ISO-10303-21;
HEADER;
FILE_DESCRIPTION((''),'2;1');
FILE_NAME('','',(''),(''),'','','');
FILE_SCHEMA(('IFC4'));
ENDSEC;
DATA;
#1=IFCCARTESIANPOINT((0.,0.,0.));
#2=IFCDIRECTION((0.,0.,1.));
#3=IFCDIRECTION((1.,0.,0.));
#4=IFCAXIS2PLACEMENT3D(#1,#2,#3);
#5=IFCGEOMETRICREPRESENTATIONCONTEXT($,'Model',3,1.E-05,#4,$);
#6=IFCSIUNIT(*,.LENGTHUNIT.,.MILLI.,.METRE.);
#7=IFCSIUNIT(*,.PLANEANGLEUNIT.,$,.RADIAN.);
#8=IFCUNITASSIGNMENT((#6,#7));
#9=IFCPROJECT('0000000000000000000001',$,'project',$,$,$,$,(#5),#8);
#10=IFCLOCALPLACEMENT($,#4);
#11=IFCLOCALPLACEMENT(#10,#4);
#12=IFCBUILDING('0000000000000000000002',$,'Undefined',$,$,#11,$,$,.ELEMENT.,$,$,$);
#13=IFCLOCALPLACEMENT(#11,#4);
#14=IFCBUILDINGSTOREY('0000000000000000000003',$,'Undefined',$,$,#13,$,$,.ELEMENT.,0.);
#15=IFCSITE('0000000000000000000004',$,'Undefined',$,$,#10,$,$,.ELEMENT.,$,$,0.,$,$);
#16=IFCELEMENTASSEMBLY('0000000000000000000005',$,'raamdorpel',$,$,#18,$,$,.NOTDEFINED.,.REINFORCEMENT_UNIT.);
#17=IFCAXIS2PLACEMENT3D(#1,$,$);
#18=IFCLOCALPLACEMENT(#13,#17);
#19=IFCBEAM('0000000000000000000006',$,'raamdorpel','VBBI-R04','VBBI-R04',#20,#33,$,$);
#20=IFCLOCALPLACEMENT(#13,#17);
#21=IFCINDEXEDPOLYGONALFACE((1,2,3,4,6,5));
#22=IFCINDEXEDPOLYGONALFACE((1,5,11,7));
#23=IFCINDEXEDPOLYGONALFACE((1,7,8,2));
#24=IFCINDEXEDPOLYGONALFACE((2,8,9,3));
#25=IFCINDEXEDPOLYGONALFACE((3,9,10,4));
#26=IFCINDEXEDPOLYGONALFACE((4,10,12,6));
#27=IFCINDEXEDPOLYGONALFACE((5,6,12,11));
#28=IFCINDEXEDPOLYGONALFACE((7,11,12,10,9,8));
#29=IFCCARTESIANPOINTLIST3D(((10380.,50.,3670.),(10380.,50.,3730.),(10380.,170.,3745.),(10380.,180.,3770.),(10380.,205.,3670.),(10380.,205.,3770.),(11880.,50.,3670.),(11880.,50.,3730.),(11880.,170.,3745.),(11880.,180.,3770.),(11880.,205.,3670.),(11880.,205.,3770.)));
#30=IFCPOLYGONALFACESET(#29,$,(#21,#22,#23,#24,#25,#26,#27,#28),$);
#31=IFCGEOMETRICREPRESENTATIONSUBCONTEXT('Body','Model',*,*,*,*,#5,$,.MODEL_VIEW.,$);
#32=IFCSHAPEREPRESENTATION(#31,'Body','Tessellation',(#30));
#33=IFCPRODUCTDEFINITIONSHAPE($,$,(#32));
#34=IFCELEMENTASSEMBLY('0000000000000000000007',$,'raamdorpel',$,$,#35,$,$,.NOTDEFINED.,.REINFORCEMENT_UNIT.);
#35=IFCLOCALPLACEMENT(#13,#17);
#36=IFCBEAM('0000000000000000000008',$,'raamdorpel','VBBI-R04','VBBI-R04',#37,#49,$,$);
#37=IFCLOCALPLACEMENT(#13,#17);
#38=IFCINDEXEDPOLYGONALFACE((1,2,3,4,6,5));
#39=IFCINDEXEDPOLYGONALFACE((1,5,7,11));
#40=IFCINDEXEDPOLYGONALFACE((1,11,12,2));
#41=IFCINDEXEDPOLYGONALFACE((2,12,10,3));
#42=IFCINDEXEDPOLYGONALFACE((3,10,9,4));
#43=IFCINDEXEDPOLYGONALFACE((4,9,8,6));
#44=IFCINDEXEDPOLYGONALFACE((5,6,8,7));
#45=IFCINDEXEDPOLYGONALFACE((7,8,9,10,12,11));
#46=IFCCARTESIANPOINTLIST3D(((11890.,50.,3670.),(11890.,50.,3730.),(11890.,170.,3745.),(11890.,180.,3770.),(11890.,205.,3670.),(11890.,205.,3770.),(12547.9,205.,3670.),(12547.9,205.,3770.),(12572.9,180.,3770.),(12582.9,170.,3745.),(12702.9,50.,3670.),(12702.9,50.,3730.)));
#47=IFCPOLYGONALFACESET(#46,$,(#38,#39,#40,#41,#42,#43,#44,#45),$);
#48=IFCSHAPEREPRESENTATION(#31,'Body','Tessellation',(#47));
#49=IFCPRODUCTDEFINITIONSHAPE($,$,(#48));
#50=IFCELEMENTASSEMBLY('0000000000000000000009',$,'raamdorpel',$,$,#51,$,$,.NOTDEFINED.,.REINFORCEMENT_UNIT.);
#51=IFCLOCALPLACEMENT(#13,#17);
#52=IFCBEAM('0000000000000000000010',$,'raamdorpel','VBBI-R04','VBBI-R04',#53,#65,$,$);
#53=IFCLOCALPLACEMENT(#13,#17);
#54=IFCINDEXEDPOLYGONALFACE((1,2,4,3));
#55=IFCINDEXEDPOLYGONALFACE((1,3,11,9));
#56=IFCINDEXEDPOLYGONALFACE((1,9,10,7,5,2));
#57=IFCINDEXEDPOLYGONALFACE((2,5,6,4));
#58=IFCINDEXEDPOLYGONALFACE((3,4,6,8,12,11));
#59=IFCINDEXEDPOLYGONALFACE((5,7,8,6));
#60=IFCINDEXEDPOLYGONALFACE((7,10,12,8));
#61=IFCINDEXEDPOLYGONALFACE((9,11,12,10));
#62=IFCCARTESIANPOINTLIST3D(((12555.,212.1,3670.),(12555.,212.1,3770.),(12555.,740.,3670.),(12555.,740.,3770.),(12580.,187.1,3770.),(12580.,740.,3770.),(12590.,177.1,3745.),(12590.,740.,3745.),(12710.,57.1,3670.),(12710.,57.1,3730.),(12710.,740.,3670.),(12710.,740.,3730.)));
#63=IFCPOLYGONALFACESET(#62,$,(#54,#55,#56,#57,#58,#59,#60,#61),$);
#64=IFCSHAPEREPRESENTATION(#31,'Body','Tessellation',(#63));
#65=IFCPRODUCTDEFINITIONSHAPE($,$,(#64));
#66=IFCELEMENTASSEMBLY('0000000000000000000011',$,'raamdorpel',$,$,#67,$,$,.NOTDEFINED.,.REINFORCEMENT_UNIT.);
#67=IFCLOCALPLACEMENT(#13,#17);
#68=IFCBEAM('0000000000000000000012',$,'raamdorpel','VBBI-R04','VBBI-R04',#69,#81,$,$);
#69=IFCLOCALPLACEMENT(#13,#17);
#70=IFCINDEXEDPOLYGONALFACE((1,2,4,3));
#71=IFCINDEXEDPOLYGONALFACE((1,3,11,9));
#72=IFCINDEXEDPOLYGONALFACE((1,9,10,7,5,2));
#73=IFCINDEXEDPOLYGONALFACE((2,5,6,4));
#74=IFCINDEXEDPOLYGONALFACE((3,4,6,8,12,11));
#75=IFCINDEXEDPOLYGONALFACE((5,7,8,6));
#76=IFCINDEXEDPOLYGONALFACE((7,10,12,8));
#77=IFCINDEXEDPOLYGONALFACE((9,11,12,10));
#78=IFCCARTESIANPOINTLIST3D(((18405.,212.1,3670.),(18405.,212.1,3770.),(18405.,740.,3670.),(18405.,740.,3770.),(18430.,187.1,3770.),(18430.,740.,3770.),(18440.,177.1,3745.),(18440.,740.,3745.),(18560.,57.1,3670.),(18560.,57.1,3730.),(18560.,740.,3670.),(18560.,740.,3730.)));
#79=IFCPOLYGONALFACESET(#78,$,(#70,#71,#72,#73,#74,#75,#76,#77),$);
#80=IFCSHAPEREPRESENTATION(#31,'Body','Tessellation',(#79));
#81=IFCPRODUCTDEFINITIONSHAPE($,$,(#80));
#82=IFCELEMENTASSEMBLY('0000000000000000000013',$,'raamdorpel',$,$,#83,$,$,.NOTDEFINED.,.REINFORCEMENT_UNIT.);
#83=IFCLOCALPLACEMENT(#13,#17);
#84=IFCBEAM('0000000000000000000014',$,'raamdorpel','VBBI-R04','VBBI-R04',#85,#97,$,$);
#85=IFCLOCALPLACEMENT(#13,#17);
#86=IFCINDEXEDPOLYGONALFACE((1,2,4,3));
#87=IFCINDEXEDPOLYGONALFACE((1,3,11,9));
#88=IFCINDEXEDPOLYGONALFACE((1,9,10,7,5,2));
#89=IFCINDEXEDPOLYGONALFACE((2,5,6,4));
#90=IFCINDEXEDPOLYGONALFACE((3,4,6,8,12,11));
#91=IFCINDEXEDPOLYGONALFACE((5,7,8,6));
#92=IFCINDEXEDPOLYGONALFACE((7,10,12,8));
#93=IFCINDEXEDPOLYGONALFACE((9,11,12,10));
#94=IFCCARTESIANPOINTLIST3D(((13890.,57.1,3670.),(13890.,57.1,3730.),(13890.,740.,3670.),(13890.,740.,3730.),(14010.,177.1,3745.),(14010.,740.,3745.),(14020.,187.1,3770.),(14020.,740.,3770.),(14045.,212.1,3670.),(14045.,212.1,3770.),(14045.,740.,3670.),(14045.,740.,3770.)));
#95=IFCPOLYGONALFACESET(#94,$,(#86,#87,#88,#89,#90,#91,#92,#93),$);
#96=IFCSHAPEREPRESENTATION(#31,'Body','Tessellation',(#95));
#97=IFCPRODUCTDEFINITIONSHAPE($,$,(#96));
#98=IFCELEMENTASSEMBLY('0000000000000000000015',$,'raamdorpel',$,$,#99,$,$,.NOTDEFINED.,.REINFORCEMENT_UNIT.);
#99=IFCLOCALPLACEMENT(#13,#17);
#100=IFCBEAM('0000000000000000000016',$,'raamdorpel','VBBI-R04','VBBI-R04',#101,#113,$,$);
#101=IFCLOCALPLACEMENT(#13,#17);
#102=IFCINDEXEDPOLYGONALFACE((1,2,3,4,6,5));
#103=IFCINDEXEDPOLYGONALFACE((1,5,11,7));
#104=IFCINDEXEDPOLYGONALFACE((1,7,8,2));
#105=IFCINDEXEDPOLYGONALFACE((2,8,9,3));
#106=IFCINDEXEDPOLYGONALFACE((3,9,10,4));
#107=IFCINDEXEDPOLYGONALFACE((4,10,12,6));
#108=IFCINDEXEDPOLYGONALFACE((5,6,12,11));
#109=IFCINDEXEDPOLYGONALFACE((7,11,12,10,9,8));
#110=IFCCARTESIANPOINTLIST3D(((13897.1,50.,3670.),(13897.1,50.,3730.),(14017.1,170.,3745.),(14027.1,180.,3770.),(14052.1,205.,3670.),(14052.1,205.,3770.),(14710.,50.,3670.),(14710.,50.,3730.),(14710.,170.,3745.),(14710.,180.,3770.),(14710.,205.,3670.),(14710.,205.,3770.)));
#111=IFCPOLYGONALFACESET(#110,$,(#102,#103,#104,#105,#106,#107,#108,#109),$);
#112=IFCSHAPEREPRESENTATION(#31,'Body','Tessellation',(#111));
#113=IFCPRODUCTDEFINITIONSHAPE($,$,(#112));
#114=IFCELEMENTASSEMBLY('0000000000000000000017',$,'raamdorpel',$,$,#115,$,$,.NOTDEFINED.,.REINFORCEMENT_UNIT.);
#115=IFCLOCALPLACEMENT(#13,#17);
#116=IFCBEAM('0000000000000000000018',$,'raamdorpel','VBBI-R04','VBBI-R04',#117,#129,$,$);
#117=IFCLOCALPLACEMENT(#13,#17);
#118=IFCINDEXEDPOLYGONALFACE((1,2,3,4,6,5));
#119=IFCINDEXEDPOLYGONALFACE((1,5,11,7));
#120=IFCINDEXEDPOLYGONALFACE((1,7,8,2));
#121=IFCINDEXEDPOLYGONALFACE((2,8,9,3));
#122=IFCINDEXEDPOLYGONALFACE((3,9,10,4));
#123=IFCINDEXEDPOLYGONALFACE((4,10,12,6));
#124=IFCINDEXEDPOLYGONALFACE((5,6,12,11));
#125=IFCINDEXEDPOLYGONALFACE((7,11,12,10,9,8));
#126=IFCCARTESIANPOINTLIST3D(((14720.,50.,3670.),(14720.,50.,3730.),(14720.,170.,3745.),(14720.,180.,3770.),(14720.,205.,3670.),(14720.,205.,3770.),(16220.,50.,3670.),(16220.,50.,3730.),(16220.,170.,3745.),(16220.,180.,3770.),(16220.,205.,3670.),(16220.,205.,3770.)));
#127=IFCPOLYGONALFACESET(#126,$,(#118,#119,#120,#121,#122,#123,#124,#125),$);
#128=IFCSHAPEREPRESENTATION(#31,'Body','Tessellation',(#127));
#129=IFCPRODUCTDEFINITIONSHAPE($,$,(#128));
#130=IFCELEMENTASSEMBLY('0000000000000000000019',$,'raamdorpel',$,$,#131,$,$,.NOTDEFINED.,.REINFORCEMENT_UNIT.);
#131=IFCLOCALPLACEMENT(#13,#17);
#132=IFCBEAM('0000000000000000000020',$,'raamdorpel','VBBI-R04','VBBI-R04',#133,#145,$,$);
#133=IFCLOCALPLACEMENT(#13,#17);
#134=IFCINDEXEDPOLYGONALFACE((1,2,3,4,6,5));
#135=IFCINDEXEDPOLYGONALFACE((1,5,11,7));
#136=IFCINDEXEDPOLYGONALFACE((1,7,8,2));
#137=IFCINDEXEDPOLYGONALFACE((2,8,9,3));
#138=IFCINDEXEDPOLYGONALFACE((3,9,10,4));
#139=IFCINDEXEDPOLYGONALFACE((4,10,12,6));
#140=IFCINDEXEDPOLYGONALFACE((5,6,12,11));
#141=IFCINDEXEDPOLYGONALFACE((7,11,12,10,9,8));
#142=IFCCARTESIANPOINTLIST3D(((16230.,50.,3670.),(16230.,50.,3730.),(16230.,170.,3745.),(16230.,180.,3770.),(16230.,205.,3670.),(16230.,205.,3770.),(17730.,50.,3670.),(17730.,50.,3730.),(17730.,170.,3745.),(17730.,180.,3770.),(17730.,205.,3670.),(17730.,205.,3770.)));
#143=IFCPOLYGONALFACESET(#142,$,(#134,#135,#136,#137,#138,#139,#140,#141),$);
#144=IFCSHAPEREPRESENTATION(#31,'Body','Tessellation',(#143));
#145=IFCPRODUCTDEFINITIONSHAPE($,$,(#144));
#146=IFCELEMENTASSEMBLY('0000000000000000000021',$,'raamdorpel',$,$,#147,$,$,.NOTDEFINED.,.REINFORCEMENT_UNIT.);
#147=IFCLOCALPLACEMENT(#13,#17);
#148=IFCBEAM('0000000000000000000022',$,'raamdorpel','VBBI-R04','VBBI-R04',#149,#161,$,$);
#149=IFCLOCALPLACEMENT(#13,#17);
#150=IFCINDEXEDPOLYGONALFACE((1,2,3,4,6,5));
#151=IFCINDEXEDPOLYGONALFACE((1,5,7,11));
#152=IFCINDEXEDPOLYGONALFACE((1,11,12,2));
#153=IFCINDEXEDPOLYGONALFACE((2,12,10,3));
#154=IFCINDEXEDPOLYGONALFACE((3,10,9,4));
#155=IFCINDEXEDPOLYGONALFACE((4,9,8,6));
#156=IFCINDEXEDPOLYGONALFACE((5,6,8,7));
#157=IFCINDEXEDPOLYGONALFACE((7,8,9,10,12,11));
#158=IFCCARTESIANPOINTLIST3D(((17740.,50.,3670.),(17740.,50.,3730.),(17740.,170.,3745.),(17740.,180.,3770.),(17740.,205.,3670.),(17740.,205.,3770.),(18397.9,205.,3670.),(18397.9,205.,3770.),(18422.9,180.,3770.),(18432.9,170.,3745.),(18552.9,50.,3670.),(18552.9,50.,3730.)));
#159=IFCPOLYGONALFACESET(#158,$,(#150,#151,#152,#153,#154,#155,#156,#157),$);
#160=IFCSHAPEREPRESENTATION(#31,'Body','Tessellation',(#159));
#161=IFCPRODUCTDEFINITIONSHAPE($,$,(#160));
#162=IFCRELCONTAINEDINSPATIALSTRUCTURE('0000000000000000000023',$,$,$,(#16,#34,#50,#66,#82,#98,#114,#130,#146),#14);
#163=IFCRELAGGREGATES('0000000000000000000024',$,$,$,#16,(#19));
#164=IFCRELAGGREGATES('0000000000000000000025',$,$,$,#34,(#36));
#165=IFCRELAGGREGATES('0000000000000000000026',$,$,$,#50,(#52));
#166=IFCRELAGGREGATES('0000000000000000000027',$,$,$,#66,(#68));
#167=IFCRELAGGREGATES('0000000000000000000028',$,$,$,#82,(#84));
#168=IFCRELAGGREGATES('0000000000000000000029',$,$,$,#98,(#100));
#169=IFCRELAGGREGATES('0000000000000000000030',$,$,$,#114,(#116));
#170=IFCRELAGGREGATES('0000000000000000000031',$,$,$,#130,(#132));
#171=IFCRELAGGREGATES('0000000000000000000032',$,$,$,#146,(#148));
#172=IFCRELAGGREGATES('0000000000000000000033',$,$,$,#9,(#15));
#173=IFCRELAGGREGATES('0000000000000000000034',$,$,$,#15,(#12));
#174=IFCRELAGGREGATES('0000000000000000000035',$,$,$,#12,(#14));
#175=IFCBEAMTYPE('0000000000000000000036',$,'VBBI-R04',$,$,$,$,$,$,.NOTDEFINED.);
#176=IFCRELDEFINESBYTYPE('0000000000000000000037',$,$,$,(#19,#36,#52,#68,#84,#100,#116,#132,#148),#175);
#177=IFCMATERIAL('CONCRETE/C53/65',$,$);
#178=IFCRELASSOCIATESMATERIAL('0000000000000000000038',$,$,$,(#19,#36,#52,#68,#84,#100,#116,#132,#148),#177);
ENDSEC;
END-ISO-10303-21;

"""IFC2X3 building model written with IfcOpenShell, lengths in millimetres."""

from ifc_helpers import new_model, si_unit, frame, origin_with_axes, place, context, subcontext, project, spatial, polyline, outline, extrude, clip, halfspace, material, type_object, element, aggregate, save


model = new_model("IFC2X3")

# Units and contexts
model_context = context("Model", 3, precision=1e-05, world=origin_with_axes())
body_context = subcontext(model_context, "Body", "Model", "MODEL_VIEW")
ifc_project = project(units=[si_unit("LENGTHUNIT", "METRE", prefix="MILLI"), si_unit("PLANEANGLEUNIT", "RADIAN")], contexts=[model_context])

# Site, building, storey
site_placement = place(None, origin_with_axes())
site = spatial("IfcSite", under=ifc_project, at=site_placement, Name="Undefined", CompositionType="ELEMENT", RefElevation=0.0)
building_placement = place(site_placement, origin_with_axes())
building = spatial("IfcBuilding", under=site, at=building_placement, Name="Undefined", CompositionType="ELEMENT")
storey_placement = place(building_placement, origin_with_axes())
storey = spatial("IfcBuildingStorey", under=building, at=storey_placement, Name="Undefined", CompositionType="ELEMENT", Elevation=0.0)

# Element assemblies, beams
ifc_material = material(Name="CONCRETE/C53/65")
beam_type_1 = type_object("IfcBeamType", Name="VBBI-R04", PredefinedType="NOTDEFINED")
assembly_1_placement = place(storey_placement, origin_with_axes())
assembly_1 = element("IfcElementAssembly", 1, at=assembly_1_placement, inside=storey, Name="raamdorpel", AssemblyPlace="NOTDEFINED", PredefinedType="REINFORCEMENT_UNIT")
beam_1_placement = place(assembly_1_placement, frame((10380.0, 127.5, 3720.0), z_axis=(0.0, -1.0, 0.0), x_axis=(1.0, 0.0, 0.0)))
beam_1 = element("IfcBeam", 2, at=beam_1_placement, type_object=beam_type_1, material=ifc_material, Name="raamdorpel", Description="VBBI-R04", ObjectType="VBBI-R04", context=body_context, shape_type="SweptSolid", body=[
    extrude(outline(polyline([(50.0, -77.5), (-50.0, -77.5), (-50.0, -52.5), (-25.0, -42.5), (-10.0, 77.5), (50.0, 77.5), (50.0, -77.5)])), frame((1500.0, 0.0, 0.0), z_axis=(-1.0, 0.0, 0.0), x_axis=(0.0, -1.0, 0.0)), (0.0, 0.0, 1.0), 1500.0),
])
aggregate(assembly_1, [beam_1])
assembly_2_placement = place(storey_placement, origin_with_axes())
assembly_2 = element("IfcElementAssembly", 3, at=assembly_2_placement, inside=storey, Name="raamdorpel", AssemblyPlace="NOTDEFINED", PredefinedType="REINFORCEMENT_UNIT")
beam_2_placement = place(assembly_2_placement, frame((11890.0, 127.5, 3720.0), z_axis=(-0.000001, -1.0, 0.0), x_axis=(1.0, -0.000001, 0.0)))
beam_2 = element("IfcBeam", 4, at=beam_2_placement, type_object=beam_type_1, material=ifc_material, Name="raamdorpel", Description="VBBI-R04", ObjectType="VBBI-R04", context=body_context, shape_type="Clipping", body=[
    clip(extrude(outline(polyline([(50.0, -77.5), (-50.0, -77.5), (-50.0, -52.5), (-25.0, -42.5), (-10.0, 77.5), (50.0, 77.5), (50.0, -77.5)])), frame((813.7, 0.0, 0.0), z_axis=(-1.0, 0.0, 0.0), x_axis=(0.0, -1.0, 0.0)), (0.0, 0.0, 1.0), 813.7), halfspace(frame((816.5, 0.0, 81.0), z_axis=(0.707107, 0.0, -0.707107), x_axis=(0.0, 1.0, 0.0)), False)),
])
aggregate(assembly_2, [beam_2])
assembly_3_placement = place(storey_placement, origin_with_axes())
assembly_3 = element("IfcElementAssembly", 5, at=assembly_3_placement, inside=storey, Name="raamdorpel", AssemblyPlace="NOTDEFINED", PredefinedType="REINFORCEMENT_UNIT")
beam_3_placement = place(assembly_3_placement, frame((12632.5, 50.0, 3720.0), z_axis=(1.0, -0.000002, 0.0), x_axis=(0.000002, 1.0, 0.0)))
beam_3 = element("IfcBeam", 6, at=beam_3_placement, type_object=beam_type_1, material=ifc_material, Name="raamdorpel", Description="VBBI-R04", ObjectType="VBBI-R04", context=body_context, shape_type="Clipping", body=[
    clip(extrude(outline(polyline([(50.0, -77.5), (-50.0, -77.5), (-50.0, -52.5), (-25.0, -42.5), (-10.0, 77.5), (50.0, 77.5), (50.0, -77.5)])), frame((690.0, 0.0, 0.0), z_axis=(-1.0, 0.0, 0.0), x_axis=(0.0, -1.0, 0.0)), (0.0, 0.0, 1.0), 683.7), halfspace(frame((3.5, 0.0, 81.0), z_axis=(0.707107, 0.0, 0.707107), x_axis=(0.0, 1.0, 0.0)), True)),
])
aggregate(assembly_3, [beam_3])
assembly_4_placement = place(storey_placement, origin_with_axes())
assembly_4 = element("IfcElementAssembly", 7, at=assembly_4_placement, inside=storey, Name="raamdorpel", AssemblyPlace="NOTDEFINED", PredefinedType="REINFORCEMENT_UNIT")
beam_4_placement = place(assembly_4_placement, frame((18482.5, 50.0, 3720.0), z_axis=(1.0, 0.0, 0.0), x_axis=(0.0, 1.0, 0.0)))
beam_4 = element("IfcBeam", 8, at=beam_4_placement, type_object=beam_type_1, material=ifc_material, Name="raamdorpel", Description="VBBI-R04", ObjectType="VBBI-R04", context=body_context, shape_type="Clipping", body=[
    clip(extrude(outline(polyline([(50.0, -77.5), (-50.0, -77.5), (-50.0, -52.5), (-25.0, -42.5), (-10.0, 77.5), (50.0, 77.5), (50.0, -77.5)])), frame((690.0, 0.0, 0.0), z_axis=(-1.0, 0.0, 0.0), x_axis=(0.0, -1.0, 0.0)), (0.0, 0.0, 1.0), 683.7), halfspace(frame((3.5, 0.0, 81.0), z_axis=(0.707107, 0.0, 0.707107), x_axis=(0.0, 1.0, 0.0)), True)),
])
aggregate(assembly_4, [beam_4])
assembly_5_placement = place(storey_placement, origin_with_axes())
assembly_5 = element("IfcElementAssembly", 9, at=assembly_5_placement, inside=storey, Name="raamdorpel", AssemblyPlace="NOTDEFINED", PredefinedType="REINFORCEMENT_UNIT")
beam_5_placement = place(assembly_5_placement, frame((13967.5, 740.0, 3720.0), z_axis=(-1.0, 0.0, 0.0), x_axis=(0.0, -1.0, 0.0)))
beam_5 = element("IfcBeam", 10, at=beam_5_placement, type_object=beam_type_1, material=ifc_material, Name="raamdorpel", Description="VBBI-R04", ObjectType="VBBI-R04", context=body_context, shape_type="Clipping", body=[
    clip(extrude(outline(polyline([(50.0, -77.5), (-50.0, -77.5), (-50.0, -52.5), (-25.0, -42.5), (-10.0, 77.5), (50.0, 77.5), (50.0, -77.5)])), frame((683.7, 0.0, 0.0), z_axis=(-1.0, 0.0, 0.0), x_axis=(0.0, -1.0, 0.0)), (0.0, 0.0, 1.0), 683.7), halfspace(frame((686.5, 0.0, 81.0), z_axis=(0.707107, 0.0, -0.707107), x_axis=(0.0, 1.0, 0.0)), False)),
])
aggregate(assembly_5, [beam_5])
assembly_6_placement = place(storey_placement, origin_with_axes())
assembly_6 = element("IfcElementAssembly", 11, at=assembly_6_placement, inside=storey, Name="raamdorpel", AssemblyPlace="NOTDEFINED", PredefinedType="REINFORCEMENT_UNIT")
beam_6_placement = place(assembly_6_placement, frame((13890.0, 127.5, 3720.0), z_axis=(0.0, -1.0, 0.0), x_axis=(1.0, 0.0, 0.0)))
beam_6 = element("IfcBeam", 12, at=beam_6_placement, type_object=beam_type_1, material=ifc_material, Name="raamdorpel", Description="VBBI-R04", ObjectType="VBBI-R04", context=body_context, shape_type="Clipping", body=[
    clip(extrude(outline(polyline([(50.0, -77.5), (-50.0, -77.5), (-50.0, -52.5), (-25.0, -42.5), (-10.0, 77.5), (50.0, 77.5), (50.0, -77.5)])), frame((820.0, 0.0, 0.0), z_axis=(-1.0, 0.0, 0.0), x_axis=(0.0, -1.0, 0.0)), (0.0, 0.0, 1.0), 813.7), halfspace(frame((3.5, 0.0, 81.0), z_axis=(0.707107, 0.0, 0.707107), x_axis=(0.0, 1.0, 0.0)), True)),
])
aggregate(assembly_6, [beam_6])
assembly_7_placement = place(storey_placement, origin_with_axes())
assembly_7 = element("IfcElementAssembly", 13, at=assembly_7_placement, inside=storey, Name="raamdorpel", AssemblyPlace="NOTDEFINED", PredefinedType="REINFORCEMENT_UNIT")
beam_7_placement = place(assembly_7_placement, frame((14720.0, 127.5, 3720.0), z_axis=(0.0, -1.0, 0.0), x_axis=(1.0, 0.0, 0.0)))
beam_7 = element("IfcBeam", 14, at=beam_7_placement, type_object=beam_type_1, material=ifc_material, Name="raamdorpel", Description="VBBI-R04", ObjectType="VBBI-R04", context=body_context, shape_type="SweptSolid", body=[
    extrude(outline(polyline([(50.0, -77.5), (-50.0, -77.5), (-50.0, -52.5), (-25.0, -42.5), (-10.0, 77.5), (50.0, 77.5), (50.0, -77.5)])), frame((1500.0, 0.0, 0.0), z_axis=(-1.0, 0.0, 0.0), x_axis=(0.0, -1.0, 0.0)), (0.0, 0.0, 1.0), 1500.0),
])
aggregate(assembly_7, [beam_7])
assembly_8_placement = place(storey_placement, origin_with_axes())
assembly_8 = element("IfcElementAssembly", 15, at=assembly_8_placement, inside=storey, Name="raamdorpel", AssemblyPlace="NOTDEFINED", PredefinedType="REINFORCEMENT_UNIT")
beam_8_placement = place(assembly_8_placement, frame((16230.0, 127.5, 3720.0), z_axis=(0.0, -1.0, 0.0), x_axis=(1.0, 0.0, 0.0)))
beam_8 = element("IfcBeam", 16, at=beam_8_placement, type_object=beam_type_1, material=ifc_material, Name="raamdorpel", Description="VBBI-R04", ObjectType="VBBI-R04", context=body_context, shape_type="SweptSolid", body=[
    extrude(outline(polyline([(50.0, -77.5), (-50.0, -77.5), (-50.0, -52.5), (-25.0, -42.5), (-10.0, 77.5), (50.0, 77.5), (50.0, -77.5)])), frame((1500.0, 0.0, 0.0), z_axis=(-1.0, 0.0, 0.0), x_axis=(0.0, -1.0, 0.0)), (0.0, 0.0, 1.0), 1500.0),
])
aggregate(assembly_8, [beam_8])
assembly_9_placement = place(storey_placement, origin_with_axes())
assembly_9 = element("IfcElementAssembly", 17, at=assembly_9_placement, inside=storey, Name="raamdorpel", AssemblyPlace="NOTDEFINED", PredefinedType="REINFORCEMENT_UNIT")
beam_9_placement = place(assembly_9_placement, frame((17740.0, 127.5, 3720.0), z_axis=(-0.000001, -1.0, 0.0), x_axis=(1.0, -0.000001, 0.0)))
beam_9 = element("IfcBeam", 18, at=beam_9_placement, type_object=beam_type_1, material=ifc_material, Name="raamdorpel", Description="VBBI-R04", ObjectType="VBBI-R04", context=body_context, shape_type="Clipping", body=[
    clip(extrude(outline(polyline([(50.0, -77.5), (-50.0, -77.5), (-50.0, -52.5), (-25.0, -42.5), (-10.0, 77.5), (50.0, 77.5), (50.0, -77.5)])), frame((813.7, 0.0, 0.0), z_axis=(-1.0, 0.0, 0.0), x_axis=(0.0, -1.0, 0.0)), (0.0, 0.0, 1.0), 813.7), halfspace(frame((816.5, 0.0, 81.0), z_axis=(0.707106, 0.0, -0.707107), x_axis=(0.0, 1.0, 0.0)), False)),
])
aggregate(assembly_9, [beam_9])

save(model, "model.ifc")
